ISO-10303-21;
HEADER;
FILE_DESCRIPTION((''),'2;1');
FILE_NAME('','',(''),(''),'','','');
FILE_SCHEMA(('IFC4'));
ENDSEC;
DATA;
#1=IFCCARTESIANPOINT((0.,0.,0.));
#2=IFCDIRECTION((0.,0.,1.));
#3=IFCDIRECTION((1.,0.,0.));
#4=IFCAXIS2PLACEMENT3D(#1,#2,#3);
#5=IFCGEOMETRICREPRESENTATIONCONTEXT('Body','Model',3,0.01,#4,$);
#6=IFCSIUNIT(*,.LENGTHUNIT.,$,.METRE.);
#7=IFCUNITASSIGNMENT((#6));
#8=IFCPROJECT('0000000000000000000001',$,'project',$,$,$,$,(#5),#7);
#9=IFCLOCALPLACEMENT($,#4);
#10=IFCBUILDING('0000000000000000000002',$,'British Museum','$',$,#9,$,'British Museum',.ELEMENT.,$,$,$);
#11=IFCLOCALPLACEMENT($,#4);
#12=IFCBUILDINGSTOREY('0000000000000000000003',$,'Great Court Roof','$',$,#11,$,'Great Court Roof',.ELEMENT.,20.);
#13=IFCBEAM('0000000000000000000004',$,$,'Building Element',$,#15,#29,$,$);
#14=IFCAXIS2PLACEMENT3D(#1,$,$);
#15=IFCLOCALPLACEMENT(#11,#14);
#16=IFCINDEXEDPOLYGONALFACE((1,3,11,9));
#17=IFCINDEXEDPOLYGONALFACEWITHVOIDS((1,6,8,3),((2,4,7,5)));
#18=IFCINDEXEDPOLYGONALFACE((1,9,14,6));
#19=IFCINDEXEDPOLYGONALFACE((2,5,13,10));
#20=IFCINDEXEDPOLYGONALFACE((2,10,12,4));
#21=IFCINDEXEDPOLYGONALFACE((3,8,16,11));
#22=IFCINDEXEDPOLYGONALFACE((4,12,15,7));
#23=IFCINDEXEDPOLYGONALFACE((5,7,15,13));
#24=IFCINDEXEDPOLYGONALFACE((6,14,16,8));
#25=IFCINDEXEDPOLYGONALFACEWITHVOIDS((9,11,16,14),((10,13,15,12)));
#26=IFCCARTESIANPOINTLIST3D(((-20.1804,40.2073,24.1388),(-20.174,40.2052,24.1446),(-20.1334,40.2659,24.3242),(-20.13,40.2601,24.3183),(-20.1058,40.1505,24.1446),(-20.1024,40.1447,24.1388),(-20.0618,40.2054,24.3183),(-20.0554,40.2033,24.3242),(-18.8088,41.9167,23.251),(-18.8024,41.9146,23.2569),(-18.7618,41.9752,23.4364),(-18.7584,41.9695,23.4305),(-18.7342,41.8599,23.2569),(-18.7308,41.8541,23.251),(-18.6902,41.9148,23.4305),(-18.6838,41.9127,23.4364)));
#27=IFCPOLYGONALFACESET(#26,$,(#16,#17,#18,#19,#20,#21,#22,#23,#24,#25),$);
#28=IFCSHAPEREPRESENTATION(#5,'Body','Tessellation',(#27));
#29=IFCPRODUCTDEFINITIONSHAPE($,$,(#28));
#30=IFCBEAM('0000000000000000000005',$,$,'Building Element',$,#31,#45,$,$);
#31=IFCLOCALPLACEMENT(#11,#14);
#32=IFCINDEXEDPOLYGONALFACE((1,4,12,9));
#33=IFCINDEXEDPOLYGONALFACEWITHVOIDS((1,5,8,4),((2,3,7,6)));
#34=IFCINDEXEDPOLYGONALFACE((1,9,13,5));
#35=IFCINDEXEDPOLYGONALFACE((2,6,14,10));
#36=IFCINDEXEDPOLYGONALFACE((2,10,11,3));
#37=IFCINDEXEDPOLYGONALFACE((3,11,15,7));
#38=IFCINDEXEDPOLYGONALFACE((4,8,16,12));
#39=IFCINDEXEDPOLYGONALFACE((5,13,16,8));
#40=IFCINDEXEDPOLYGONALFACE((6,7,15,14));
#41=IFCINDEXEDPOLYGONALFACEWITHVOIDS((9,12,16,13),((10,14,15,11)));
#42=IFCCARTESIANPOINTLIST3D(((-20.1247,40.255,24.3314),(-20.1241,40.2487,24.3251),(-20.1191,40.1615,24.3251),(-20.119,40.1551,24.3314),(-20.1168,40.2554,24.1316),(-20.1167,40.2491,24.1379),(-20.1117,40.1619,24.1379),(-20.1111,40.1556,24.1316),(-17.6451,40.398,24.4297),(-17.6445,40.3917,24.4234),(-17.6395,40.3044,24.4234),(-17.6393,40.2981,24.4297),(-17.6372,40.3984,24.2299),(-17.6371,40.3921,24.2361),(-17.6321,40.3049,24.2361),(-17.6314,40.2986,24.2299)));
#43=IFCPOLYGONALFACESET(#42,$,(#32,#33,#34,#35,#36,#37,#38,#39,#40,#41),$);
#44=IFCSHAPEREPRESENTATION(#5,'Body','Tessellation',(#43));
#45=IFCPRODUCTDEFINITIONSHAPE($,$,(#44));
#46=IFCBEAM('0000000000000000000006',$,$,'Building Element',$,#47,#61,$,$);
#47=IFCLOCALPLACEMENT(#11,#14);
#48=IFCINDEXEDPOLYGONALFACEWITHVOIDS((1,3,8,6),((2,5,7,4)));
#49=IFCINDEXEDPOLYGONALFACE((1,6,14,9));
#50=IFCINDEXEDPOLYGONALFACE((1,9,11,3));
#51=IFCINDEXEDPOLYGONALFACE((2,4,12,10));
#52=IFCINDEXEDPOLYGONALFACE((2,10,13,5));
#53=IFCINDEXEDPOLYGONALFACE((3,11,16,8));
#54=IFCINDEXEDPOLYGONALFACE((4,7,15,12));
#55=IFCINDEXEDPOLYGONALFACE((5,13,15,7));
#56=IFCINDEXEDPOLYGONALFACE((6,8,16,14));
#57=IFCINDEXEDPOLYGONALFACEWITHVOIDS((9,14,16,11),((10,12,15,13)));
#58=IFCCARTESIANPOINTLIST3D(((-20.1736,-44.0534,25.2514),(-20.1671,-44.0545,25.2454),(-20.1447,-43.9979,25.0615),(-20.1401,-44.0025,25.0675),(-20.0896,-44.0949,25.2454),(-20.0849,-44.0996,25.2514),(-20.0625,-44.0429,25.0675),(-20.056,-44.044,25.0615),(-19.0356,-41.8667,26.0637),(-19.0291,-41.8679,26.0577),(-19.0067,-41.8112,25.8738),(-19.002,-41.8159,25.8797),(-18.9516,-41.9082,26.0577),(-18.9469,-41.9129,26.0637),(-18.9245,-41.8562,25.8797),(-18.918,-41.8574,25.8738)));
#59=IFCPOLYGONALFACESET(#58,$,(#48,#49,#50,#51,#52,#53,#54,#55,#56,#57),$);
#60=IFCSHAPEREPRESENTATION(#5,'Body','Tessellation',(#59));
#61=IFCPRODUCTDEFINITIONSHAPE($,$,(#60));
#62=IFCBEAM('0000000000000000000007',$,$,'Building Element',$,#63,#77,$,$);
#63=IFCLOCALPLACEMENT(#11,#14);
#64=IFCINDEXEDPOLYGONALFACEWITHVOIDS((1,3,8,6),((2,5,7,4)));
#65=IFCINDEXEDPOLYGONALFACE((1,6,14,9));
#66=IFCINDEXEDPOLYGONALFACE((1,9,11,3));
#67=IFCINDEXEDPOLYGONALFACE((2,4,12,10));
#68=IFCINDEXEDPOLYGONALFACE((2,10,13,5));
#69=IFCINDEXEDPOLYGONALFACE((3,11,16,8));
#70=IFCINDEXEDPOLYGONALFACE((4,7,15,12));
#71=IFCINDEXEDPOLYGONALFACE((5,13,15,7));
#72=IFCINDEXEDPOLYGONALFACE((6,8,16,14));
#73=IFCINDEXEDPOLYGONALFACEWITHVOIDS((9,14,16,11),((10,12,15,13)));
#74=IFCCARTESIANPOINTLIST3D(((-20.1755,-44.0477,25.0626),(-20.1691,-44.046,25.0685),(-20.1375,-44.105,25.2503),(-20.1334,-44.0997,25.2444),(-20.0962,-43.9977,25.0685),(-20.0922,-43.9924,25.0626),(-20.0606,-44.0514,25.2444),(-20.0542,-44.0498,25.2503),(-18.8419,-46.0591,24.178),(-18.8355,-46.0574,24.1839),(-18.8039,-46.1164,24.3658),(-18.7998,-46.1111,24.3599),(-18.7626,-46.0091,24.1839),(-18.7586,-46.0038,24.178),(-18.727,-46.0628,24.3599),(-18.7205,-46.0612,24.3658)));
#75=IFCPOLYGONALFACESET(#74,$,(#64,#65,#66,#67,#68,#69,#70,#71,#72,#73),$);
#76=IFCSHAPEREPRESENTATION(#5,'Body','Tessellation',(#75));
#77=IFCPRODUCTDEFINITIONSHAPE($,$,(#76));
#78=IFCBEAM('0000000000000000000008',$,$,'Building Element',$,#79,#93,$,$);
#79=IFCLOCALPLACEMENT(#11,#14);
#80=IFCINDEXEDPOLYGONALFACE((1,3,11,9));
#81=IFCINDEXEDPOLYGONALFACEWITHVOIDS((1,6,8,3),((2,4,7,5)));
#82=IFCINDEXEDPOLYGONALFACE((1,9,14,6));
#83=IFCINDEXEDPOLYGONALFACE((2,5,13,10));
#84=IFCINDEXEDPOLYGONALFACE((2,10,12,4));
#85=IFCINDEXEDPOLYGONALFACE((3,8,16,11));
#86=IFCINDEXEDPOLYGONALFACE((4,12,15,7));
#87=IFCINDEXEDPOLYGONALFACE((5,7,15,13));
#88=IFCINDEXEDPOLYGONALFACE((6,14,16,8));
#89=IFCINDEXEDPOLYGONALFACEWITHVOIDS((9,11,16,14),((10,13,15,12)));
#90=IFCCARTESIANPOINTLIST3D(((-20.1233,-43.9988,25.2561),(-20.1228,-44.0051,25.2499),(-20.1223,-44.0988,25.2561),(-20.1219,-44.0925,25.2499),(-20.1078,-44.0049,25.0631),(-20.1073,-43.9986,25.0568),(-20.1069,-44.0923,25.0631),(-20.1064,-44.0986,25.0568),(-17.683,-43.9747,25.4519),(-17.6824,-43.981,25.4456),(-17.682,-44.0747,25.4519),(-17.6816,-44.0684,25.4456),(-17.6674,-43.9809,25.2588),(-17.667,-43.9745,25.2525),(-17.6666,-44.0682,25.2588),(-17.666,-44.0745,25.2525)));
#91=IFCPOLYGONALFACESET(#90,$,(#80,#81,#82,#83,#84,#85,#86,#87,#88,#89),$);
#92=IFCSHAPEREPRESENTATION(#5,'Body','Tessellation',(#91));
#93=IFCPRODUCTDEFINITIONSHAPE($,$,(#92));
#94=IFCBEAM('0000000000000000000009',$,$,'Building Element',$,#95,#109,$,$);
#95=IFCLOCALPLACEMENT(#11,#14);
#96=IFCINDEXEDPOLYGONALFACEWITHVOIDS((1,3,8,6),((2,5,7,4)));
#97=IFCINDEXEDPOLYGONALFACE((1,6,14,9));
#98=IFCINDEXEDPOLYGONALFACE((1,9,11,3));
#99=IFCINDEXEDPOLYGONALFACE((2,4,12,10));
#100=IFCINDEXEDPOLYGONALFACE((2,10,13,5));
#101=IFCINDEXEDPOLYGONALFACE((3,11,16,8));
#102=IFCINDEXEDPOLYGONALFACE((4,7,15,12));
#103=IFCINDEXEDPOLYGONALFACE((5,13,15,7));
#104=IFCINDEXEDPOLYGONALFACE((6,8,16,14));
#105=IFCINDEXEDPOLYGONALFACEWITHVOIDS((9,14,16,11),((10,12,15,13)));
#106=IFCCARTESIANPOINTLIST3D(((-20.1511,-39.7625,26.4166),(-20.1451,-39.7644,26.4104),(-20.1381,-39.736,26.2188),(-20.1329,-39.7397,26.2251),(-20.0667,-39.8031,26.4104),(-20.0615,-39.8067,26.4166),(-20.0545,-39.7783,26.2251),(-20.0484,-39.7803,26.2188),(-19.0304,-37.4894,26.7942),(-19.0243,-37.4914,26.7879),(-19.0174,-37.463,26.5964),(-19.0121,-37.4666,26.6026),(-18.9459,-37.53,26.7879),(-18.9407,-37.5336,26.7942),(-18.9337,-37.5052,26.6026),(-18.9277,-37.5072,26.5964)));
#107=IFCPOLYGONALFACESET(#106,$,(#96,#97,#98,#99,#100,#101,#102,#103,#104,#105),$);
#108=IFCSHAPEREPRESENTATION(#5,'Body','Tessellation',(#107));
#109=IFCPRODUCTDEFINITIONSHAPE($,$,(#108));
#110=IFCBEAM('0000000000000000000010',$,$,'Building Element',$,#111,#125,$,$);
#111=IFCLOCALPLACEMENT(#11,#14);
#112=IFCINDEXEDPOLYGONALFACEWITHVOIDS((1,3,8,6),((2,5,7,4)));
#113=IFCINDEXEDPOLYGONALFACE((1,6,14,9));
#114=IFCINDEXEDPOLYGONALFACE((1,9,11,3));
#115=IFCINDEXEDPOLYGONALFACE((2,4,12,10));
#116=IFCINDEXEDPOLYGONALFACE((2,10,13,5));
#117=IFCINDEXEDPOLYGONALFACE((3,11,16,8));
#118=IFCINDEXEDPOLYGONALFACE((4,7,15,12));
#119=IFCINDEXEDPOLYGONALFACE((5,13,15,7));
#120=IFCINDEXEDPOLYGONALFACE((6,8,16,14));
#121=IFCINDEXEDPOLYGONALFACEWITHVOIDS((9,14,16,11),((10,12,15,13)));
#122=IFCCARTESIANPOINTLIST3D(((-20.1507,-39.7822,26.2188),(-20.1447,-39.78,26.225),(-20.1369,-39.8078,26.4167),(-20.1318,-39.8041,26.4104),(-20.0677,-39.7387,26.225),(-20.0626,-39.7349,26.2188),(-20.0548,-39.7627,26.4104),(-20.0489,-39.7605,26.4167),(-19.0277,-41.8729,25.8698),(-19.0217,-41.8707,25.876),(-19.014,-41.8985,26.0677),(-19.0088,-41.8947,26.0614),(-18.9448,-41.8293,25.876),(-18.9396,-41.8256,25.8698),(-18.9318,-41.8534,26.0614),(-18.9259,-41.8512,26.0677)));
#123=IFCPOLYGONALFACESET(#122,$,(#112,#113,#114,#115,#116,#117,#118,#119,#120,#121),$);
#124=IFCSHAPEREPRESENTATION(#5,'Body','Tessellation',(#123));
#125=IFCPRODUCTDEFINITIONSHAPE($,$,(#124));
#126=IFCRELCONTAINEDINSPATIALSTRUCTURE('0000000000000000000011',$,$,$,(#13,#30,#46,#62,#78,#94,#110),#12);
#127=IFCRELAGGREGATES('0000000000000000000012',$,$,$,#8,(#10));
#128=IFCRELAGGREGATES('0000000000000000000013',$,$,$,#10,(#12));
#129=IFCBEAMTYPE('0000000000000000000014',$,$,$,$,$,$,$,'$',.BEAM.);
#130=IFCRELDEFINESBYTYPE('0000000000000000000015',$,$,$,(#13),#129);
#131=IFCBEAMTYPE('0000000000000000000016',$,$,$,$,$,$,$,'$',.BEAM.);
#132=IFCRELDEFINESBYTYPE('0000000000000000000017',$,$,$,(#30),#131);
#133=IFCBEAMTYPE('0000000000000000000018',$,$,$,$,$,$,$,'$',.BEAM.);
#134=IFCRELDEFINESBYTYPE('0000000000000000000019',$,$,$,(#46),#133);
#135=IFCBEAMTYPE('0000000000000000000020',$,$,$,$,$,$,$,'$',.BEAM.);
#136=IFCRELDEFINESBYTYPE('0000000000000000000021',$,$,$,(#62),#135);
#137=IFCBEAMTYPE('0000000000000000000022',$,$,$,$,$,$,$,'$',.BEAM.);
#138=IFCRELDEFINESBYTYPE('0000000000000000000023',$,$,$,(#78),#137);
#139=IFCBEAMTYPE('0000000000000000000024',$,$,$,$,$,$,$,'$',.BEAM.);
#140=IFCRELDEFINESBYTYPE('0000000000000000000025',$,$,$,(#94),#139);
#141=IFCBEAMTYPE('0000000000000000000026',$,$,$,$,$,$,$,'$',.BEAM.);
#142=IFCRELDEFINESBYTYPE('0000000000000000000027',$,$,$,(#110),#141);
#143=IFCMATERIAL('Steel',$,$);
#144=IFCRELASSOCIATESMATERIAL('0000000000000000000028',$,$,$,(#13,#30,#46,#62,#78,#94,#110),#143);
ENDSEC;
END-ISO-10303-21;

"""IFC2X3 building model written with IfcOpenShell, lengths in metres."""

from ifc_helpers import new_model, si_unit, frame, origin_with_axes, origin_2d, place, context, project, spatial, hollow_rectangle, extrude, material, type_object, element, save


model = new_model("IFC2X3")

# Units and contexts
model_context = context("Model", 3, precision=0.01, world=origin_with_axes(), identifier="Body")
ifc_project = project(units=[si_unit("LENGTHUNIT", "METRE")], contexts=[model_context])

# Building, storey
building_placement = place(None, origin_with_axes())
building = spatial("IfcBuilding", under=ifc_project, at=building_placement, Name="British Museum", Description="$", LongName="British Museum", CompositionType="ELEMENT")
storey_placement = place(None, origin_with_axes())
storey = spatial("IfcBuildingStorey", under=building, at=storey_placement, Name="Great Court Roof", Description="$", LongName="Great Court Roof", CompositionType="ELEMENT", Elevation=20.0)

# Beams
ifc_material = material(Name="Steel")
beam_type_1 = type_object("IfcBeamType", ElementType="$", PredefinedType="BEAM")
beam_1_placement = place(None, origin_with_axes())
element("IfcBeam", 1, at=beam_1_placement, inside=storey, type_object=beam_type_1, material=ifc_material, Description="Building Element", context=model_context, shape_type="SweptSolid", body=[
    extrude(hollow_rectangle(XDim=0.1, YDim=0.2, WallThickness=0.0063, InnerFilletRadius=-0.0063, OuterFilletRadius=0.0, at=origin_2d()), frame((-20.1179, 40.2053, 24.2315), z_axis=(0.580048, 0.7229, -0.375446), x_axis=(-0.779958, 0.625831, 0.0)), (0.0, 0.0, 1.0), 2.3646),
])
beam_type_2 = type_object("IfcBeamType", ElementType="$", PredefinedType="BEAM")
beam_2_placement = place(None, origin_with_axes())
element("IfcBeam", 2, at=beam_2_placement, inside=storey, type_object=beam_type_2, material=ifc_material, Description="Building Element", context=model_context, shape_type="SweptSolid", body=[
    extrude(hollow_rectangle(XDim=0.1, YDim=0.2, WallThickness=0.0063, InnerFilletRadius=-0.0063, OuterFilletRadius=0.0, at=origin_2d()), frame((-20.1179, 40.2053, 24.2315), z_axis=(0.997561, 0.057519, 0.039544), x_axis=(-0.057564, 0.998342, 0.0)), (0.0, 0.0, 1.0), 2.4857),
])
beam_type_3 = type_object("IfcBeamType", ElementType="$", PredefinedType="BEAM")
beam_3_placement = place(None, origin_with_axes())
element("IfcBeam", 3, at=beam_3_placement, inside=storey, type_object=beam_type_3, material=ifc_material, Description="Building Element", context=model_context, shape_type="SweptSolid", body=[
    extrude(hollow_rectangle(XDim=0.1, YDim=0.2, WallThickness=0.0063, InnerFilletRadius=-0.0063, OuterFilletRadius=0.0, at=origin_2d()), frame((-20.1148, -44.0487, 25.1565), z_axis=(0.438473, 0.842495, 0.312959), x_axis=(-0.887055, 0.461664, 0.0)), (0.0, 0.0, 1.0), 2.5955),
])
beam_type_4 = type_object("IfcBeamType", ElementType="$", PredefinedType="BEAM")
beam_4_placement = place(None, origin_with_axes())
element("IfcBeam", 4, at=beam_4_placement, inside=storey, type_object=beam_type_4, material=ifc_material, Description="Building Element", context=model_context, shape_type="SweptSolid", body=[
    extrude(hollow_rectangle(XDim=0.1, YDim=0.2, WallThickness=0.0063, InnerFilletRadius=-0.0063, OuterFilletRadius=0.0, at=origin_2d()), frame((-20.1148, -44.0487, 25.1565), z_axis=(0.518847, -0.782538, -0.344139), x_axis=(0.833446, 0.552601, 0.0)), (0.0, 0.0, 1.0), 2.5704),
])
beam_type_5 = type_object("IfcBeamType", ElementType="$", PredefinedType="BEAM")
beam_5_placement = place(None, origin_with_axes())
element("IfcBeam", 5, at=beam_5_placement, inside=storey, type_object=beam_type_5, material=ifc_material, Description="Building Element", context=model_context, shape_type="SweptSolid", body=[
    extrude(hollow_rectangle(XDim=0.1, YDim=0.2, WallThickness=0.0063, InnerFilletRadius=-0.0063, OuterFilletRadius=0.0, at=origin_2d()), frame((-20.1148, -44.0487, 25.1565), z_axis=(0.996749, 0.009838, 0.079961), x_axis=(-0.009869, 0.999951, 0.0)), (0.0, 0.0, 1.0), 2.4483),
])
beam_type_6 = type_object("IfcBeamType", ElementType="$", PredefinedType="BEAM")
beam_6_placement = place(None, origin_with_axes())
element("IfcBeam", 6, at=beam_6_placement, inside=storey, type_object=beam_type_6, material=ifc_material, Description="Building Element", context=model_context, shape_type="SweptSolid", body=[
    extrude(hollow_rectangle(XDim=0.1, YDim=0.2, WallThickness=0.0063, InnerFilletRadius=-0.0063, OuterFilletRadius=0.0, at=origin_2d()), frame((-20.0998, -39.7714, 26.3177), z_axis=(0.437398, 0.887115, 0.147339), x_axis=(-0.896904, 0.442225, 0.0)), (0.0, 0.0, 1.0), 2.5623),
])
beam_type_7 = type_object("IfcBeamType", ElementType="$", PredefinedType="BEAM")
beam_7_placement = place(None, origin_with_axes())
element("IfcBeam", 7, at=beam_7_placement, inside=storey, type_object=beam_type_7, material=ifc_material, Description="Building Element", context=model_context, shape_type="SweptSolid", body=[
    extrude(hollow_rectangle(XDim=0.1, YDim=0.2, WallThickness=0.0063, InnerFilletRadius=-0.0063, OuterFilletRadius=0.0, at=origin_2d()), frame((-20.0998, -39.7714, 26.3177), z_axis=(0.468163, -0.871581, -0.145497), x_axis=(0.880956, 0.473199, 0.0)), (0.0, 0.0, 1.0), 2.3987),
])

save(model, "model.ifc")
